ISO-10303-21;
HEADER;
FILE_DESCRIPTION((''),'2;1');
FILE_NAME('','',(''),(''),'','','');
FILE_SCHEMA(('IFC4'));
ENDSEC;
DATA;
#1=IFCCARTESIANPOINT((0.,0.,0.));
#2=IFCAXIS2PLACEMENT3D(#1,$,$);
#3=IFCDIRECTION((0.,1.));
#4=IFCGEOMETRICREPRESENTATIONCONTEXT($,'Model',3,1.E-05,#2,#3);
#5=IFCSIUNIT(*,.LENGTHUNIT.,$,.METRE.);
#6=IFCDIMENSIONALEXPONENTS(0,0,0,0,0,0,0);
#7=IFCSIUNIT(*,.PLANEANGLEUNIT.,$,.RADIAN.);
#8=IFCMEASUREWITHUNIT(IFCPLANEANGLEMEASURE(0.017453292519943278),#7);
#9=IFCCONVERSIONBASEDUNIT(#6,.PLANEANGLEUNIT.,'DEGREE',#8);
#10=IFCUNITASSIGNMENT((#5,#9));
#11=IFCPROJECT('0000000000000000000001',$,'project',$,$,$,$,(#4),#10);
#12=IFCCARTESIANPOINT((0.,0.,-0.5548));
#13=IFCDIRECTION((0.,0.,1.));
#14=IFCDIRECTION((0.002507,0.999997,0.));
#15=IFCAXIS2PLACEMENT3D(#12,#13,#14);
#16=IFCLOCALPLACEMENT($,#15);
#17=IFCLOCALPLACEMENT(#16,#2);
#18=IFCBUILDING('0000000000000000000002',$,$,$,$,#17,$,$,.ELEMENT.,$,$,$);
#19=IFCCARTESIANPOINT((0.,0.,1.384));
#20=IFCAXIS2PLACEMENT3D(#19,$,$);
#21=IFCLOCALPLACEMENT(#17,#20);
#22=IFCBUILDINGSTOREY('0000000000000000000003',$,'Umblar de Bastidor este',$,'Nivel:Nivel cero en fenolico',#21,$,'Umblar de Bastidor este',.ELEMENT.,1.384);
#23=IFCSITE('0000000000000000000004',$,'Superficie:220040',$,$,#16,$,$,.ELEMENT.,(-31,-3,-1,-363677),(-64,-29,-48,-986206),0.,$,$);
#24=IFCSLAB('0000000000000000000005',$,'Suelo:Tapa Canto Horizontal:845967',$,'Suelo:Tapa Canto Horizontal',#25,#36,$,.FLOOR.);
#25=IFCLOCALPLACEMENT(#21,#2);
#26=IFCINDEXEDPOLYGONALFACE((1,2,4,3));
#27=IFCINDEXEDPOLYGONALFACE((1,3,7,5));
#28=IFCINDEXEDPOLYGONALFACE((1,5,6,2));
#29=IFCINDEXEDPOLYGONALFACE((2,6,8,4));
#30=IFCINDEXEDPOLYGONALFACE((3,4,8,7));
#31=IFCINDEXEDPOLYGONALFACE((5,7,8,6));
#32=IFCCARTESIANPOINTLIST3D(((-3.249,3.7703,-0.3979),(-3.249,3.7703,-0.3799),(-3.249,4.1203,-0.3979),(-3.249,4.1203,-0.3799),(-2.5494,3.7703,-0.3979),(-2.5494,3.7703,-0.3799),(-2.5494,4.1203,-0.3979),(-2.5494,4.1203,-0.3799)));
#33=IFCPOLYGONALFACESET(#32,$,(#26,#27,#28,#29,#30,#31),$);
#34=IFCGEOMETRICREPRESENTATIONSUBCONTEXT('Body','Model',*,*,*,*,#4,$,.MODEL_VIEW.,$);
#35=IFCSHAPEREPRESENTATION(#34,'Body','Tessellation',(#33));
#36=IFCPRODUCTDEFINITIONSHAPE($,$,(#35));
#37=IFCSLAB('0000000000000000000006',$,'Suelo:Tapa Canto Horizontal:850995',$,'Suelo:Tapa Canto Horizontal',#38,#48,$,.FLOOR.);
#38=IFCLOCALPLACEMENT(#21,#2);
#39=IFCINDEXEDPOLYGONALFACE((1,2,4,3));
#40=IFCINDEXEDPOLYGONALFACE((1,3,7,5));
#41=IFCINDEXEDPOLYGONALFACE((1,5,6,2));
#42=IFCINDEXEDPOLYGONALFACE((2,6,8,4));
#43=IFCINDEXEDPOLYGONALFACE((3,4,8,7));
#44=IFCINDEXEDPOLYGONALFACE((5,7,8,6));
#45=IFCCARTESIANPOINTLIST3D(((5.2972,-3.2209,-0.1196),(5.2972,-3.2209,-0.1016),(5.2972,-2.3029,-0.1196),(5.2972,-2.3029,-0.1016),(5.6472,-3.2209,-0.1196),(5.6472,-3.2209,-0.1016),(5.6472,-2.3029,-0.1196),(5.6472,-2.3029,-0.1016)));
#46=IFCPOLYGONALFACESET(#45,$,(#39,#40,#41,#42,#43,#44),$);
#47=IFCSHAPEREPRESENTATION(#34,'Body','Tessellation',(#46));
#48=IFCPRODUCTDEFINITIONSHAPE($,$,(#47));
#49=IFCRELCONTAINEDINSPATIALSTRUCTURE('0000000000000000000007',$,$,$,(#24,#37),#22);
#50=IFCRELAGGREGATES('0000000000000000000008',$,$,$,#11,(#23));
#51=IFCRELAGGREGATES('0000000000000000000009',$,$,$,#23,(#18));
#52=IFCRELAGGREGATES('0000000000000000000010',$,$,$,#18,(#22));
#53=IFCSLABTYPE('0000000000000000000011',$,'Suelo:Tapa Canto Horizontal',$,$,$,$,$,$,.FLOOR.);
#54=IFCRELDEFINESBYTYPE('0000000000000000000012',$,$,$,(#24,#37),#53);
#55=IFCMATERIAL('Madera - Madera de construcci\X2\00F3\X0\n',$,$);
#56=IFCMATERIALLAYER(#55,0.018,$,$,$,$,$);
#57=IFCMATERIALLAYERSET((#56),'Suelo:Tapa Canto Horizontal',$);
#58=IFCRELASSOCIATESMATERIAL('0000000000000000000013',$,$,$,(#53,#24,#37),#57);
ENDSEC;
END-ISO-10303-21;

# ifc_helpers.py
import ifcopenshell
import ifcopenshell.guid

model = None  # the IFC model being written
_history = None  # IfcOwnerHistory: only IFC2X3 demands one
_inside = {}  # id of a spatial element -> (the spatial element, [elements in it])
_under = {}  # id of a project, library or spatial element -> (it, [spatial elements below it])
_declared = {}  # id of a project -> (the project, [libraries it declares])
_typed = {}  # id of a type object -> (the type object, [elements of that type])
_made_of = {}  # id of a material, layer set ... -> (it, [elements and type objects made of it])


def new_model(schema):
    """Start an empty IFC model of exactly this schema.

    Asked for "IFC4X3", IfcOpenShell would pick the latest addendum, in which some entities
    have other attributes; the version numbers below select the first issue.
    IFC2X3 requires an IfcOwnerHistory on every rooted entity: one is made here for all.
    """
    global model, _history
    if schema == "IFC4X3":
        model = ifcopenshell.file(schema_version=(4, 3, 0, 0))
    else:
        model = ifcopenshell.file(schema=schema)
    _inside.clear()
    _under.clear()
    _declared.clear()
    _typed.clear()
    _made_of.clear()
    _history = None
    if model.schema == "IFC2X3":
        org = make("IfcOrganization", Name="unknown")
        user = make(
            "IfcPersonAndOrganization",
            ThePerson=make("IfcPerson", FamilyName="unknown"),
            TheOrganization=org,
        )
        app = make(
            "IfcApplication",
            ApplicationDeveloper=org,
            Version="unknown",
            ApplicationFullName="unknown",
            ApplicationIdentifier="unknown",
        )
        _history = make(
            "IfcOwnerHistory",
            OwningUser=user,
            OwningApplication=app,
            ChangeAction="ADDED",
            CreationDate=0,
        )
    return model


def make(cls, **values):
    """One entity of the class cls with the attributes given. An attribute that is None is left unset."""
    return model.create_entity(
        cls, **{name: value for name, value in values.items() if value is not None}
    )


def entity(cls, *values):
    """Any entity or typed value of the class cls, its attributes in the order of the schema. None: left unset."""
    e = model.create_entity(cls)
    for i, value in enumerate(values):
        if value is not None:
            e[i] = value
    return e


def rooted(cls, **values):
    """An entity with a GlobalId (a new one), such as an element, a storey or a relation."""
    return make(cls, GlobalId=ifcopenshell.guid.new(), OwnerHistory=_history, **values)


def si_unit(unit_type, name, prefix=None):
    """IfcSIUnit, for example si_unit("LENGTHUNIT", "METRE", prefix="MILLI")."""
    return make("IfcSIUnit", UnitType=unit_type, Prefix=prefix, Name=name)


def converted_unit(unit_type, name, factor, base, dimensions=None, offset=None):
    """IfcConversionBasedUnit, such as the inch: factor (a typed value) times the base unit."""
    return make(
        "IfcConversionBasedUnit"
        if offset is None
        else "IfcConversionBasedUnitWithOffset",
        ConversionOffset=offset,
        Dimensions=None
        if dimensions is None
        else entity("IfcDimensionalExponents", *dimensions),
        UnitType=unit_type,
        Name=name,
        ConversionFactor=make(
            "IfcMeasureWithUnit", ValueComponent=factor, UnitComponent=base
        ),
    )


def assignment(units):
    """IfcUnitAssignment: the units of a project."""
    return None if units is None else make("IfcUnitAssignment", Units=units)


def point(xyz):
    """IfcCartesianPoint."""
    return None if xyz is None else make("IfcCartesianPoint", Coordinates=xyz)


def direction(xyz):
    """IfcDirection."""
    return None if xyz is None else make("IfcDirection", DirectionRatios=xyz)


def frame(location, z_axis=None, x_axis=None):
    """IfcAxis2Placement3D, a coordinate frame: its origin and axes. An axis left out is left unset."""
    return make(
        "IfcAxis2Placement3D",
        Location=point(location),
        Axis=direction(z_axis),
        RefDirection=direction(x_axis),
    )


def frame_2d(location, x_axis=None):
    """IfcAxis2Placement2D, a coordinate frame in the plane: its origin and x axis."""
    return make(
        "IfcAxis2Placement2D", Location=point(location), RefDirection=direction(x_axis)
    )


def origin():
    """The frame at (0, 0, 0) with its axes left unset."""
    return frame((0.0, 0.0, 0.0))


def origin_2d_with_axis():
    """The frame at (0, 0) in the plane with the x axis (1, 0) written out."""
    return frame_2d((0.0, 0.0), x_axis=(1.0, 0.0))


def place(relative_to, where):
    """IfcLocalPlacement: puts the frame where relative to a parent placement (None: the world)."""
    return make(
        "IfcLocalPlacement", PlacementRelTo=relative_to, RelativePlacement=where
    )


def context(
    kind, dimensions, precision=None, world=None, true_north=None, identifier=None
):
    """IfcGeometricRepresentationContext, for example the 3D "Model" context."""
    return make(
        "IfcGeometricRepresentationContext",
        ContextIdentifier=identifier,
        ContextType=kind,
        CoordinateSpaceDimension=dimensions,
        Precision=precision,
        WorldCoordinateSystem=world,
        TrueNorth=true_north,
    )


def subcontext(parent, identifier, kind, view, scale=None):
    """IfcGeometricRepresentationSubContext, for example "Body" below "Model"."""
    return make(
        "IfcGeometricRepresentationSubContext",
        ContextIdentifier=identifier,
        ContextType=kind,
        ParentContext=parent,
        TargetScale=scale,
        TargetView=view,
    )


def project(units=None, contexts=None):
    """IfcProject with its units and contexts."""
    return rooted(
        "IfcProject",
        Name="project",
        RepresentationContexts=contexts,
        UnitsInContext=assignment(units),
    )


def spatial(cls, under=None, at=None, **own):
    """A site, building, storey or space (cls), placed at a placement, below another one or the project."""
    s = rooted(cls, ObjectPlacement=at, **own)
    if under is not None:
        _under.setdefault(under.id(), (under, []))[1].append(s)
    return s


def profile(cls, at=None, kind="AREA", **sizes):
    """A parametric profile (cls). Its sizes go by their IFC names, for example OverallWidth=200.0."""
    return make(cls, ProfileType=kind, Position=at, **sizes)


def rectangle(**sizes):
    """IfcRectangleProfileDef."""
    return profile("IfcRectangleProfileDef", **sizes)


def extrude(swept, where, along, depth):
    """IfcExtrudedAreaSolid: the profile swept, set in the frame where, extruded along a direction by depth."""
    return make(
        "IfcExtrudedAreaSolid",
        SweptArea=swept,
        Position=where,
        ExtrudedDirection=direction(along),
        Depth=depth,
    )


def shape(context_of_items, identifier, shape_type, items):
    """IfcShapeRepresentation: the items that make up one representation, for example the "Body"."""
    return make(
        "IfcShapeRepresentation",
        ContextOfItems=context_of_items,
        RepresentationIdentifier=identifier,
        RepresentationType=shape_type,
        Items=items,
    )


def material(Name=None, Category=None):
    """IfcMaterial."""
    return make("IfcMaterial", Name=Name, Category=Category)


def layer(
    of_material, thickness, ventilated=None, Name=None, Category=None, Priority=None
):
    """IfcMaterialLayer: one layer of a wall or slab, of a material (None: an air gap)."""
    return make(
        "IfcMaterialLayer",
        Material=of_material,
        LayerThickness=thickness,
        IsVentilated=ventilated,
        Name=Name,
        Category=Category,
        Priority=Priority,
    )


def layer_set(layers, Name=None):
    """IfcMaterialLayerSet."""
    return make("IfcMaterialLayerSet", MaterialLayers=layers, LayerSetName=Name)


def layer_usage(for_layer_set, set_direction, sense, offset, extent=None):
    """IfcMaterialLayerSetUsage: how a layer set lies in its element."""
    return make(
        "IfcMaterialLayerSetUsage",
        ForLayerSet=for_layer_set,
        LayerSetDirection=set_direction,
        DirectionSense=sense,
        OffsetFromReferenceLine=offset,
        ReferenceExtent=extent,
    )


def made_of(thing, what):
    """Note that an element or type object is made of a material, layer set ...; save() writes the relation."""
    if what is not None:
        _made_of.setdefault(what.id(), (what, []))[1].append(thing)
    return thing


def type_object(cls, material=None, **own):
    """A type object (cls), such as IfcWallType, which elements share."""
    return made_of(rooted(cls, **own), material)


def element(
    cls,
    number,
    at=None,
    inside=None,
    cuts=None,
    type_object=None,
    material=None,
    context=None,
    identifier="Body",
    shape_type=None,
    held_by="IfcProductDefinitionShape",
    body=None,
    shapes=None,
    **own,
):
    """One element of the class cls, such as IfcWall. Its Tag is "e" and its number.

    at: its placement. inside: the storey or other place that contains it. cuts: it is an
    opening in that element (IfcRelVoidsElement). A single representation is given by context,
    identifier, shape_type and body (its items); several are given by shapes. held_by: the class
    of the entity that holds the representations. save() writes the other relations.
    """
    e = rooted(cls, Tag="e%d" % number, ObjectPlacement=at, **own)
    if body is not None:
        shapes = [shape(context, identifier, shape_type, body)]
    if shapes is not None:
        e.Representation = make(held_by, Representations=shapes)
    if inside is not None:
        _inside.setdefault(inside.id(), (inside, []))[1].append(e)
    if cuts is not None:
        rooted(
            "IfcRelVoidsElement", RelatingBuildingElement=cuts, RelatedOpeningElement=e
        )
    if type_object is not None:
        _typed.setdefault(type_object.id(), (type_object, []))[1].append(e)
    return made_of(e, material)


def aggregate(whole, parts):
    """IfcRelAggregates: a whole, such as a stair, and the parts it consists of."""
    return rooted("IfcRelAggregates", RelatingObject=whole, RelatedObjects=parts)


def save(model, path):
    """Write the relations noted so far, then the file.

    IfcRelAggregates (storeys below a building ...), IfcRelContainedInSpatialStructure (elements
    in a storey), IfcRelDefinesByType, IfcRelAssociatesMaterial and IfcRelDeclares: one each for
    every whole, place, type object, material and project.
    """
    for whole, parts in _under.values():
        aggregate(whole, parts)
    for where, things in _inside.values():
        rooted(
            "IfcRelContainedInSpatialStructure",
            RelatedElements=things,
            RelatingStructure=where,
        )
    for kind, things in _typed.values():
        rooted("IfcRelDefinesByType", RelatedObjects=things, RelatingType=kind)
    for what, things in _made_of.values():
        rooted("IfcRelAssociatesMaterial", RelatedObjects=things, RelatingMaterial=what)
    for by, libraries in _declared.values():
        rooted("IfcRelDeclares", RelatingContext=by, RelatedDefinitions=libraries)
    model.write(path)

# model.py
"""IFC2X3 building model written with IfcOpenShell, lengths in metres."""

from ifc_helpers import new_model, entity, si_unit, converted_unit, direction, frame, frame_2d, origin, origin_2d_with_axis, place, context, subcontext, project, spatial, rectangle, extrude, material, layer, layer_set, layer_usage, type_object, element, save


model = new_model("IFC2X3")

# Units and contexts
model_context = context("Model", 3, precision=1e-05, world=origin(), true_north=direction((0.0, 1.0)))
body_context = subcontext(model_context, "Body", "Model", "MODEL_VIEW")
ifc_project = project(units=[si_unit("LENGTHUNIT", "METRE"), converted_unit("PLANEANGLEUNIT", "DEGREE", entity("IfcPlaneAngleMeasure", 0.017453292519943278), si_unit("PLANEANGLEUNIT", "RADIAN"), dimensions=[0, 0, 0, 0, 0, 0, 0])], contexts=[model_context])

# Site, building, storey
site_placement = place(None, frame((0.0, 0.0, -0.5548), z_axis=(0.0, 0.0, 1.0), x_axis=(0.002507, 0.999997, 0.0)))
site = spatial("IfcSite", under=ifc_project, at=site_placement, Name="Superficie:220040", CompositionType="ELEMENT", RefLatitude=(-31, -3, -1, -363677), RefLongitude=(-64, -29, -48, -986206), RefElevation=0.0)
building_placement = place(site_placement, origin())
building = spatial("IfcBuilding", under=site, at=building_placement, CompositionType="ELEMENT")
storey_placement = place(building_placement, frame((0.0, 0.0, 1.384)))
storey = spatial("IfcBuildingStorey", under=building, at=storey_placement, Name="Umblar de Bastidor este", ObjectType="Nivel:Nivel cero en fenolico", LongName="Umblar de Bastidor este", CompositionType="ELEMENT", Elevation=1.384)

# Shared definitions
ifc_material = material(Name="Madera - Madera de construcción")

# Slabs
ifc_layer = layer(ifc_material, 0.018)
ifc_layer_set = layer_set([ifc_layer], Name="Suelo:Tapa Canto Horizontal")
ifc_layer_usage = layer_usage(ifc_layer_set, "AXIS3", "POSITIVE", 0.0)
slab_type = type_object("IfcSlabType", Name="Suelo:Tapa Canto Horizontal", PredefinedType="FLOOR", material=ifc_layer_set)
slab_1_placement = place(storey_placement, origin())
element("IfcSlab", 1, at=slab_1_placement, inside=storey, type_object=slab_type, material=ifc_layer_usage, Name="Suelo:Tapa Canto Horizontal:845967", ObjectType="Suelo:Tapa Canto Horizontal", PredefinedType="FLOOR", context=body_context, shape_type="SweptSolid", body=[
    extrude(rectangle(XDim=0.35, YDim=0.6996, at=frame_2d((0.0, 0.0), x_axis=(1.0, 0.0))), frame((-2.8992, 3.9453, -0.3799), z_axis=(0.0, 0.0, -1.0), x_axis=(0.0, 1.0, 0.0)), (0.0, 0.0, 1.0), 0.018),
])
slab_2_placement = place(storey_placement, origin())
element("IfcSlab", 2, at=slab_2_placement, inside=storey, type_object=slab_type, material=ifc_layer_usage, Name="Suelo:Tapa Canto Horizontal:850995", ObjectType="Suelo:Tapa Canto Horizontal", PredefinedType="FLOOR", context=body_context, shape_type="SweptSolid", body=[
    extrude(rectangle(XDim=0.918, YDim=0.35, at=origin_2d_with_axis()), frame((5.4722, -2.7619, -0.1016), z_axis=(0.0, 0.0, -1.0), x_axis=(0.0, 1.0, 0.0)), (0.0, 0.0, 1.0), 0.018),
])

save(model, "model.ifc")
